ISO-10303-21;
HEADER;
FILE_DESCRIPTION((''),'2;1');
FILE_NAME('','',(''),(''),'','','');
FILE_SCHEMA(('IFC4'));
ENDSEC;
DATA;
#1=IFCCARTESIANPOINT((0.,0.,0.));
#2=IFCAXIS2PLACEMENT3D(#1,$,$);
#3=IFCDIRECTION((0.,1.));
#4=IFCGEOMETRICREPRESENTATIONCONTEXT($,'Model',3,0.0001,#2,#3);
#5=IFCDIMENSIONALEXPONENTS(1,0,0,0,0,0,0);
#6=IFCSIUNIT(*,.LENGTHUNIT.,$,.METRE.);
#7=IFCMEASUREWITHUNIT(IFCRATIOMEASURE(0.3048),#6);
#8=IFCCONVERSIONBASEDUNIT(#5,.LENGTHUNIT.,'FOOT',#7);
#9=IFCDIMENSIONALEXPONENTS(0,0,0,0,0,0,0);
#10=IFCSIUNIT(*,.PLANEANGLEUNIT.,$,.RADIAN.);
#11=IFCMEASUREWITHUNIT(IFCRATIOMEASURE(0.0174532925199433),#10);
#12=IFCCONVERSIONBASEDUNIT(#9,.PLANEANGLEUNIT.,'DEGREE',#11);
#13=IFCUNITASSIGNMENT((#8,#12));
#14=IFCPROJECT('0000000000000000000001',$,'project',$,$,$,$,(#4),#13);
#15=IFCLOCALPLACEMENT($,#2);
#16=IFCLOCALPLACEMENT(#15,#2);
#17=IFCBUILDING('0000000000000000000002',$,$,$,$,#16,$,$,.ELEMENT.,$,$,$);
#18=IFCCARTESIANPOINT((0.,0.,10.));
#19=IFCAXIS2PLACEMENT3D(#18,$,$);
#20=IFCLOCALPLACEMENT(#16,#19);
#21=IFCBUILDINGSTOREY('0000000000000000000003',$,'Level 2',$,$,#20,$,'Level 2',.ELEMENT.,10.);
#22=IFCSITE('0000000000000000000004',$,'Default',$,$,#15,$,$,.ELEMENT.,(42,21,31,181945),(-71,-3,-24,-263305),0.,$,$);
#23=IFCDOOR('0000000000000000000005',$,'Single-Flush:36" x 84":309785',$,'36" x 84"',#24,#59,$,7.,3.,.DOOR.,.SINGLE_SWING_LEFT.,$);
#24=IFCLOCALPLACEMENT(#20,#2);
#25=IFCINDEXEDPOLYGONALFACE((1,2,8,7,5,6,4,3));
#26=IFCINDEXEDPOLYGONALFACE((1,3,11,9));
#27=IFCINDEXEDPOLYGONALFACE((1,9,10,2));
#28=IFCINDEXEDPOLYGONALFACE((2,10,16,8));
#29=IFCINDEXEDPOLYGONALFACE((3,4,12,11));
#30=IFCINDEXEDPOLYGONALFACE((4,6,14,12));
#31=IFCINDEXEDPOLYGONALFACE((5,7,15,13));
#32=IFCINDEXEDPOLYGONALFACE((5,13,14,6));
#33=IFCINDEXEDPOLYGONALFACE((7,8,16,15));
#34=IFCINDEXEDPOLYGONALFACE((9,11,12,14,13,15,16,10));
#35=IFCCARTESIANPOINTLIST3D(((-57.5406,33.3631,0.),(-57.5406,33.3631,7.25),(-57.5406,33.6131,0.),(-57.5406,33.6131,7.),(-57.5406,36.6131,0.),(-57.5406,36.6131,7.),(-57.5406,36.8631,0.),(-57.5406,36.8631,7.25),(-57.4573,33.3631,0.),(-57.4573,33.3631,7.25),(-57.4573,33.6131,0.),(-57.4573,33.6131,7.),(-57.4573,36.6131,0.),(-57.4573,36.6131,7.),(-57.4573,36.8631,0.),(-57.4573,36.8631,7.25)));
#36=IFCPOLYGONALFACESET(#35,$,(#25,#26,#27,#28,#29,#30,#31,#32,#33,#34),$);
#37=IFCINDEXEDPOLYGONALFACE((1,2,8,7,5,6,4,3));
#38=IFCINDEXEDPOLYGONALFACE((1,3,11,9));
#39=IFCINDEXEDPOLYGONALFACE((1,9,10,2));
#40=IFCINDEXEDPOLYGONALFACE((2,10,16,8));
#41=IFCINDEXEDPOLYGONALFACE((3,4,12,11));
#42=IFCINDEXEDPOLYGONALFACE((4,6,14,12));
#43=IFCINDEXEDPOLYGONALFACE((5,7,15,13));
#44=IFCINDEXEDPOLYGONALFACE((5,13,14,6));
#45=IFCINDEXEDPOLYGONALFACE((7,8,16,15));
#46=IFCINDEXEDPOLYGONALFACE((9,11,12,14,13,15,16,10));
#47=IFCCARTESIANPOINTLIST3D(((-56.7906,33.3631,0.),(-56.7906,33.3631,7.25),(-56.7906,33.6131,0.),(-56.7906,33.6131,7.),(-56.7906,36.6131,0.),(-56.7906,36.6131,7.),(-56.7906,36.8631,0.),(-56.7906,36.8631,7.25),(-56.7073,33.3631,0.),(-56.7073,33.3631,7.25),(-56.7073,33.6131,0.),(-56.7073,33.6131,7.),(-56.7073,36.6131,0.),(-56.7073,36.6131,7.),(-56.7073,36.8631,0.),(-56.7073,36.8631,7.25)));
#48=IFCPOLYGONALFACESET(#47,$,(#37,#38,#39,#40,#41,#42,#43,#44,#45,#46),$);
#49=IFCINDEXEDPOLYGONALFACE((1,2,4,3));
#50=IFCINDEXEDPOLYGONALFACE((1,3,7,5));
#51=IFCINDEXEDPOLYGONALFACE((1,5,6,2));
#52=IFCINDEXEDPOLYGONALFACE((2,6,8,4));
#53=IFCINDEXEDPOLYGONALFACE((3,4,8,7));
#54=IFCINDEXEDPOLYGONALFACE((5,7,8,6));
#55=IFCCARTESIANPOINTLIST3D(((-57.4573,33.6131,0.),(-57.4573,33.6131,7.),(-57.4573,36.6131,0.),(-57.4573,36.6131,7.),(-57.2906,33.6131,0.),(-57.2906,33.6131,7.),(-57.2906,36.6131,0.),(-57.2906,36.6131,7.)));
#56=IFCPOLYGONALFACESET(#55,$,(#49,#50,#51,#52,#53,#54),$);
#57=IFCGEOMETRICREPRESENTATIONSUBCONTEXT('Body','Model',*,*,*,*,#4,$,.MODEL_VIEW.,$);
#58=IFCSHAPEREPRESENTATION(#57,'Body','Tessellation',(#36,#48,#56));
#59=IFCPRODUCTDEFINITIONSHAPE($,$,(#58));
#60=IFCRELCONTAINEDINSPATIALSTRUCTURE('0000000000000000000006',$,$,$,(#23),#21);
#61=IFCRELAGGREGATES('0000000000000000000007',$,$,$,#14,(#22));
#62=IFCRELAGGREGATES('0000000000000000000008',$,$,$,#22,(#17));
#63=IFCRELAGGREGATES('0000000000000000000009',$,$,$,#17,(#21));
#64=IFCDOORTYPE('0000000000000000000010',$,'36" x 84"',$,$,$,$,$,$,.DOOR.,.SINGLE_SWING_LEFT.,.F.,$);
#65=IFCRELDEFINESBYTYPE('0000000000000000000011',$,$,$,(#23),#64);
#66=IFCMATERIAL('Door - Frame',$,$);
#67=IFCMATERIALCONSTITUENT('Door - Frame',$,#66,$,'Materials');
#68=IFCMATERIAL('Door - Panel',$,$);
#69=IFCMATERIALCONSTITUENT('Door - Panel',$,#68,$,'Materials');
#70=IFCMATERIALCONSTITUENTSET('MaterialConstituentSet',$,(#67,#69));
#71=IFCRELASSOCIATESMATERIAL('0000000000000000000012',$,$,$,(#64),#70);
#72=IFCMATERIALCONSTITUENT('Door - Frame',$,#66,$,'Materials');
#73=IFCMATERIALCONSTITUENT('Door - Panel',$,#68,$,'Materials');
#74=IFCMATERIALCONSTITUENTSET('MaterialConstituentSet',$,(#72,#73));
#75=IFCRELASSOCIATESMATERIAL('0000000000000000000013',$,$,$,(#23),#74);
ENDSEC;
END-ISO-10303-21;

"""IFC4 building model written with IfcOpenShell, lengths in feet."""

from ifc_helpers import new_model, entity, si_unit, converted_unit, direction, frame, frame_2d, origin, place, context, subcontext, project, spatial, polyline, rectangle, outline, extrude, source, transform, mapped, material, constituent, constituent_set, type_object, type_shapes, element, save


model = new_model("IFC4")

# Units and contexts
model_context = context("Model", 3, precision=0.0001, world=origin(), true_north=direction((0.0, 1.0)))
body_context = subcontext(model_context, "Body", "Model", "MODEL_VIEW")
ifc_project = project(units=[converted_unit("LENGTHUNIT", "FOOT", entity("IfcRatioMeasure", 0.3048), si_unit("LENGTHUNIT", "METRE"), dimensions=[1, 0, 0, 0, 0, 0, 0]), converted_unit("PLANEANGLEUNIT", "DEGREE", entity("IfcRatioMeasure", 0.0174532925199433), si_unit("PLANEANGLEUNIT", "RADIAN"), dimensions=[0, 0, 0, 0, 0, 0, 0])], contexts=[model_context])

# Site, building, storey
site_placement = place(None, origin())
site = spatial("IfcSite", under=ifc_project, at=site_placement, Name="Default", CompositionType="ELEMENT", RefLatitude=(42, 21, 31, 181945), RefLongitude=(-71, -3, -24, -263305), RefElevation=0.0)
building_placement = place(site_placement, origin())
building = spatial("IfcBuilding", under=site, at=building_placement, CompositionType="ELEMENT")
storey_placement = place(building_placement, frame((0.0, 0.0, 10.0)))
storey = spatial("IfcBuildingStorey", under=building, at=storey_placement, Name="Level 2", LongName="Level 2", CompositionType="ELEMENT", Elevation=10.0)

# Shared definitions
placement_1 = place(storey_placement, frame((-57.1239, 31.9464, 0.0), z_axis=(0.0, 0.0, 1.0), x_axis=(0.0, 1.0, 0.0)))

# Door
ifc_material_1 = material(Name="Door - Frame")
ifc_constituent_1 = constituent(ifc_material_1, Name="Door - Frame", Category="Materials")
ifc_material_2 = material(Name="Door - Panel")
ifc_constituent_2 = constituent(ifc_material_2, Name="Door - Panel", Category="Materials")
ifc_constituent_set_1 = constituent_set(constituents=[ifc_constituent_1, ifc_constituent_2], Name="MaterialConstituentSet")
ifc_constituent_3 = constituent(ifc_material_1, Name="Door - Frame", Category="Materials")
ifc_constituent_4 = constituent(ifc_material_2, Name="Door - Panel", Category="Materials")
ifc_constituent_set_2 = constituent_set(constituents=[ifc_constituent_3, ifc_constituent_4], Name="MaterialConstituentSet")
door_type = type_object("IfcDoorType", Name="36\" x 84\"", OperationType="SINGLE_SWING_LEFT", ParameterTakesPrecedence=False, PredefinedType="DOOR", material=ifc_constituent_set_2)
shared_shape = source(origin(), body_context, "Body", "SweptSolid", [
    extrude(outline(polyline([(-1.75, -3.6875), (1.75, -3.6875), (1.75, 3.5625), (1.5, 3.5625), (1.5, -3.4375), (-1.5, -3.4375), (-1.5, 3.5625), (-1.75, 3.5625), (-1.75, -3.6875)])), frame((1.5, 0.75, 3.5625), z_axis=(0.0, -1.0, 0.0), x_axis=(-1.0, 0.0, 0.0)), (0.0, 0.0, 1.0), 0.0833),
    extrude(outline(polyline([(-3.6875, -1.75), (3.5625, -1.75), (3.5625, -1.5), (-3.4375, -1.5), (-3.4375, 1.5), (3.5625, 1.5), (3.5625, 1.75), (-3.6875, 1.75), (-3.6875, -1.75)])), frame((1.5, 0.0, 3.5625), z_axis=(0.0, -1.0, 0.0), x_axis=(0.0, 0.0, -1.0)), (0.0, 0.0, 1.0), 0.0833),
    extrude(rectangle(XDim=3.0, YDim=0.1667, at=frame_2d((0.0, 0.0), x_axis=(1.0, 0.0))), frame((1.5, 0.5833, 0.0)), (0.0, 0.0, 1.0), 7.0),
])
type_shapes(door_type, [shared_shape])
placement_2 = place(placement_1, frame((1.6667, -0.3333, 0.0)))
door_placement = place(placement_2, origin())
element("IfcDoor", 1, at=door_placement, inside=storey, type_object=door_type, material=ifc_constituent_set_1, Name="Single-Flush:36\" x 84\":309785", ObjectType="36\" x 84\"", OperationType="SINGLE_SWING_LEFT", OverallHeight=7.0, OverallWidth=3.0, PredefinedType="DOOR", context=body_context, shape_type="MappedRepresentation", body=[
    mapped(shared_shape, transform((0.0, 0.0, 0.0), scale=1.0)),
])

save(model, "model.ifc")
